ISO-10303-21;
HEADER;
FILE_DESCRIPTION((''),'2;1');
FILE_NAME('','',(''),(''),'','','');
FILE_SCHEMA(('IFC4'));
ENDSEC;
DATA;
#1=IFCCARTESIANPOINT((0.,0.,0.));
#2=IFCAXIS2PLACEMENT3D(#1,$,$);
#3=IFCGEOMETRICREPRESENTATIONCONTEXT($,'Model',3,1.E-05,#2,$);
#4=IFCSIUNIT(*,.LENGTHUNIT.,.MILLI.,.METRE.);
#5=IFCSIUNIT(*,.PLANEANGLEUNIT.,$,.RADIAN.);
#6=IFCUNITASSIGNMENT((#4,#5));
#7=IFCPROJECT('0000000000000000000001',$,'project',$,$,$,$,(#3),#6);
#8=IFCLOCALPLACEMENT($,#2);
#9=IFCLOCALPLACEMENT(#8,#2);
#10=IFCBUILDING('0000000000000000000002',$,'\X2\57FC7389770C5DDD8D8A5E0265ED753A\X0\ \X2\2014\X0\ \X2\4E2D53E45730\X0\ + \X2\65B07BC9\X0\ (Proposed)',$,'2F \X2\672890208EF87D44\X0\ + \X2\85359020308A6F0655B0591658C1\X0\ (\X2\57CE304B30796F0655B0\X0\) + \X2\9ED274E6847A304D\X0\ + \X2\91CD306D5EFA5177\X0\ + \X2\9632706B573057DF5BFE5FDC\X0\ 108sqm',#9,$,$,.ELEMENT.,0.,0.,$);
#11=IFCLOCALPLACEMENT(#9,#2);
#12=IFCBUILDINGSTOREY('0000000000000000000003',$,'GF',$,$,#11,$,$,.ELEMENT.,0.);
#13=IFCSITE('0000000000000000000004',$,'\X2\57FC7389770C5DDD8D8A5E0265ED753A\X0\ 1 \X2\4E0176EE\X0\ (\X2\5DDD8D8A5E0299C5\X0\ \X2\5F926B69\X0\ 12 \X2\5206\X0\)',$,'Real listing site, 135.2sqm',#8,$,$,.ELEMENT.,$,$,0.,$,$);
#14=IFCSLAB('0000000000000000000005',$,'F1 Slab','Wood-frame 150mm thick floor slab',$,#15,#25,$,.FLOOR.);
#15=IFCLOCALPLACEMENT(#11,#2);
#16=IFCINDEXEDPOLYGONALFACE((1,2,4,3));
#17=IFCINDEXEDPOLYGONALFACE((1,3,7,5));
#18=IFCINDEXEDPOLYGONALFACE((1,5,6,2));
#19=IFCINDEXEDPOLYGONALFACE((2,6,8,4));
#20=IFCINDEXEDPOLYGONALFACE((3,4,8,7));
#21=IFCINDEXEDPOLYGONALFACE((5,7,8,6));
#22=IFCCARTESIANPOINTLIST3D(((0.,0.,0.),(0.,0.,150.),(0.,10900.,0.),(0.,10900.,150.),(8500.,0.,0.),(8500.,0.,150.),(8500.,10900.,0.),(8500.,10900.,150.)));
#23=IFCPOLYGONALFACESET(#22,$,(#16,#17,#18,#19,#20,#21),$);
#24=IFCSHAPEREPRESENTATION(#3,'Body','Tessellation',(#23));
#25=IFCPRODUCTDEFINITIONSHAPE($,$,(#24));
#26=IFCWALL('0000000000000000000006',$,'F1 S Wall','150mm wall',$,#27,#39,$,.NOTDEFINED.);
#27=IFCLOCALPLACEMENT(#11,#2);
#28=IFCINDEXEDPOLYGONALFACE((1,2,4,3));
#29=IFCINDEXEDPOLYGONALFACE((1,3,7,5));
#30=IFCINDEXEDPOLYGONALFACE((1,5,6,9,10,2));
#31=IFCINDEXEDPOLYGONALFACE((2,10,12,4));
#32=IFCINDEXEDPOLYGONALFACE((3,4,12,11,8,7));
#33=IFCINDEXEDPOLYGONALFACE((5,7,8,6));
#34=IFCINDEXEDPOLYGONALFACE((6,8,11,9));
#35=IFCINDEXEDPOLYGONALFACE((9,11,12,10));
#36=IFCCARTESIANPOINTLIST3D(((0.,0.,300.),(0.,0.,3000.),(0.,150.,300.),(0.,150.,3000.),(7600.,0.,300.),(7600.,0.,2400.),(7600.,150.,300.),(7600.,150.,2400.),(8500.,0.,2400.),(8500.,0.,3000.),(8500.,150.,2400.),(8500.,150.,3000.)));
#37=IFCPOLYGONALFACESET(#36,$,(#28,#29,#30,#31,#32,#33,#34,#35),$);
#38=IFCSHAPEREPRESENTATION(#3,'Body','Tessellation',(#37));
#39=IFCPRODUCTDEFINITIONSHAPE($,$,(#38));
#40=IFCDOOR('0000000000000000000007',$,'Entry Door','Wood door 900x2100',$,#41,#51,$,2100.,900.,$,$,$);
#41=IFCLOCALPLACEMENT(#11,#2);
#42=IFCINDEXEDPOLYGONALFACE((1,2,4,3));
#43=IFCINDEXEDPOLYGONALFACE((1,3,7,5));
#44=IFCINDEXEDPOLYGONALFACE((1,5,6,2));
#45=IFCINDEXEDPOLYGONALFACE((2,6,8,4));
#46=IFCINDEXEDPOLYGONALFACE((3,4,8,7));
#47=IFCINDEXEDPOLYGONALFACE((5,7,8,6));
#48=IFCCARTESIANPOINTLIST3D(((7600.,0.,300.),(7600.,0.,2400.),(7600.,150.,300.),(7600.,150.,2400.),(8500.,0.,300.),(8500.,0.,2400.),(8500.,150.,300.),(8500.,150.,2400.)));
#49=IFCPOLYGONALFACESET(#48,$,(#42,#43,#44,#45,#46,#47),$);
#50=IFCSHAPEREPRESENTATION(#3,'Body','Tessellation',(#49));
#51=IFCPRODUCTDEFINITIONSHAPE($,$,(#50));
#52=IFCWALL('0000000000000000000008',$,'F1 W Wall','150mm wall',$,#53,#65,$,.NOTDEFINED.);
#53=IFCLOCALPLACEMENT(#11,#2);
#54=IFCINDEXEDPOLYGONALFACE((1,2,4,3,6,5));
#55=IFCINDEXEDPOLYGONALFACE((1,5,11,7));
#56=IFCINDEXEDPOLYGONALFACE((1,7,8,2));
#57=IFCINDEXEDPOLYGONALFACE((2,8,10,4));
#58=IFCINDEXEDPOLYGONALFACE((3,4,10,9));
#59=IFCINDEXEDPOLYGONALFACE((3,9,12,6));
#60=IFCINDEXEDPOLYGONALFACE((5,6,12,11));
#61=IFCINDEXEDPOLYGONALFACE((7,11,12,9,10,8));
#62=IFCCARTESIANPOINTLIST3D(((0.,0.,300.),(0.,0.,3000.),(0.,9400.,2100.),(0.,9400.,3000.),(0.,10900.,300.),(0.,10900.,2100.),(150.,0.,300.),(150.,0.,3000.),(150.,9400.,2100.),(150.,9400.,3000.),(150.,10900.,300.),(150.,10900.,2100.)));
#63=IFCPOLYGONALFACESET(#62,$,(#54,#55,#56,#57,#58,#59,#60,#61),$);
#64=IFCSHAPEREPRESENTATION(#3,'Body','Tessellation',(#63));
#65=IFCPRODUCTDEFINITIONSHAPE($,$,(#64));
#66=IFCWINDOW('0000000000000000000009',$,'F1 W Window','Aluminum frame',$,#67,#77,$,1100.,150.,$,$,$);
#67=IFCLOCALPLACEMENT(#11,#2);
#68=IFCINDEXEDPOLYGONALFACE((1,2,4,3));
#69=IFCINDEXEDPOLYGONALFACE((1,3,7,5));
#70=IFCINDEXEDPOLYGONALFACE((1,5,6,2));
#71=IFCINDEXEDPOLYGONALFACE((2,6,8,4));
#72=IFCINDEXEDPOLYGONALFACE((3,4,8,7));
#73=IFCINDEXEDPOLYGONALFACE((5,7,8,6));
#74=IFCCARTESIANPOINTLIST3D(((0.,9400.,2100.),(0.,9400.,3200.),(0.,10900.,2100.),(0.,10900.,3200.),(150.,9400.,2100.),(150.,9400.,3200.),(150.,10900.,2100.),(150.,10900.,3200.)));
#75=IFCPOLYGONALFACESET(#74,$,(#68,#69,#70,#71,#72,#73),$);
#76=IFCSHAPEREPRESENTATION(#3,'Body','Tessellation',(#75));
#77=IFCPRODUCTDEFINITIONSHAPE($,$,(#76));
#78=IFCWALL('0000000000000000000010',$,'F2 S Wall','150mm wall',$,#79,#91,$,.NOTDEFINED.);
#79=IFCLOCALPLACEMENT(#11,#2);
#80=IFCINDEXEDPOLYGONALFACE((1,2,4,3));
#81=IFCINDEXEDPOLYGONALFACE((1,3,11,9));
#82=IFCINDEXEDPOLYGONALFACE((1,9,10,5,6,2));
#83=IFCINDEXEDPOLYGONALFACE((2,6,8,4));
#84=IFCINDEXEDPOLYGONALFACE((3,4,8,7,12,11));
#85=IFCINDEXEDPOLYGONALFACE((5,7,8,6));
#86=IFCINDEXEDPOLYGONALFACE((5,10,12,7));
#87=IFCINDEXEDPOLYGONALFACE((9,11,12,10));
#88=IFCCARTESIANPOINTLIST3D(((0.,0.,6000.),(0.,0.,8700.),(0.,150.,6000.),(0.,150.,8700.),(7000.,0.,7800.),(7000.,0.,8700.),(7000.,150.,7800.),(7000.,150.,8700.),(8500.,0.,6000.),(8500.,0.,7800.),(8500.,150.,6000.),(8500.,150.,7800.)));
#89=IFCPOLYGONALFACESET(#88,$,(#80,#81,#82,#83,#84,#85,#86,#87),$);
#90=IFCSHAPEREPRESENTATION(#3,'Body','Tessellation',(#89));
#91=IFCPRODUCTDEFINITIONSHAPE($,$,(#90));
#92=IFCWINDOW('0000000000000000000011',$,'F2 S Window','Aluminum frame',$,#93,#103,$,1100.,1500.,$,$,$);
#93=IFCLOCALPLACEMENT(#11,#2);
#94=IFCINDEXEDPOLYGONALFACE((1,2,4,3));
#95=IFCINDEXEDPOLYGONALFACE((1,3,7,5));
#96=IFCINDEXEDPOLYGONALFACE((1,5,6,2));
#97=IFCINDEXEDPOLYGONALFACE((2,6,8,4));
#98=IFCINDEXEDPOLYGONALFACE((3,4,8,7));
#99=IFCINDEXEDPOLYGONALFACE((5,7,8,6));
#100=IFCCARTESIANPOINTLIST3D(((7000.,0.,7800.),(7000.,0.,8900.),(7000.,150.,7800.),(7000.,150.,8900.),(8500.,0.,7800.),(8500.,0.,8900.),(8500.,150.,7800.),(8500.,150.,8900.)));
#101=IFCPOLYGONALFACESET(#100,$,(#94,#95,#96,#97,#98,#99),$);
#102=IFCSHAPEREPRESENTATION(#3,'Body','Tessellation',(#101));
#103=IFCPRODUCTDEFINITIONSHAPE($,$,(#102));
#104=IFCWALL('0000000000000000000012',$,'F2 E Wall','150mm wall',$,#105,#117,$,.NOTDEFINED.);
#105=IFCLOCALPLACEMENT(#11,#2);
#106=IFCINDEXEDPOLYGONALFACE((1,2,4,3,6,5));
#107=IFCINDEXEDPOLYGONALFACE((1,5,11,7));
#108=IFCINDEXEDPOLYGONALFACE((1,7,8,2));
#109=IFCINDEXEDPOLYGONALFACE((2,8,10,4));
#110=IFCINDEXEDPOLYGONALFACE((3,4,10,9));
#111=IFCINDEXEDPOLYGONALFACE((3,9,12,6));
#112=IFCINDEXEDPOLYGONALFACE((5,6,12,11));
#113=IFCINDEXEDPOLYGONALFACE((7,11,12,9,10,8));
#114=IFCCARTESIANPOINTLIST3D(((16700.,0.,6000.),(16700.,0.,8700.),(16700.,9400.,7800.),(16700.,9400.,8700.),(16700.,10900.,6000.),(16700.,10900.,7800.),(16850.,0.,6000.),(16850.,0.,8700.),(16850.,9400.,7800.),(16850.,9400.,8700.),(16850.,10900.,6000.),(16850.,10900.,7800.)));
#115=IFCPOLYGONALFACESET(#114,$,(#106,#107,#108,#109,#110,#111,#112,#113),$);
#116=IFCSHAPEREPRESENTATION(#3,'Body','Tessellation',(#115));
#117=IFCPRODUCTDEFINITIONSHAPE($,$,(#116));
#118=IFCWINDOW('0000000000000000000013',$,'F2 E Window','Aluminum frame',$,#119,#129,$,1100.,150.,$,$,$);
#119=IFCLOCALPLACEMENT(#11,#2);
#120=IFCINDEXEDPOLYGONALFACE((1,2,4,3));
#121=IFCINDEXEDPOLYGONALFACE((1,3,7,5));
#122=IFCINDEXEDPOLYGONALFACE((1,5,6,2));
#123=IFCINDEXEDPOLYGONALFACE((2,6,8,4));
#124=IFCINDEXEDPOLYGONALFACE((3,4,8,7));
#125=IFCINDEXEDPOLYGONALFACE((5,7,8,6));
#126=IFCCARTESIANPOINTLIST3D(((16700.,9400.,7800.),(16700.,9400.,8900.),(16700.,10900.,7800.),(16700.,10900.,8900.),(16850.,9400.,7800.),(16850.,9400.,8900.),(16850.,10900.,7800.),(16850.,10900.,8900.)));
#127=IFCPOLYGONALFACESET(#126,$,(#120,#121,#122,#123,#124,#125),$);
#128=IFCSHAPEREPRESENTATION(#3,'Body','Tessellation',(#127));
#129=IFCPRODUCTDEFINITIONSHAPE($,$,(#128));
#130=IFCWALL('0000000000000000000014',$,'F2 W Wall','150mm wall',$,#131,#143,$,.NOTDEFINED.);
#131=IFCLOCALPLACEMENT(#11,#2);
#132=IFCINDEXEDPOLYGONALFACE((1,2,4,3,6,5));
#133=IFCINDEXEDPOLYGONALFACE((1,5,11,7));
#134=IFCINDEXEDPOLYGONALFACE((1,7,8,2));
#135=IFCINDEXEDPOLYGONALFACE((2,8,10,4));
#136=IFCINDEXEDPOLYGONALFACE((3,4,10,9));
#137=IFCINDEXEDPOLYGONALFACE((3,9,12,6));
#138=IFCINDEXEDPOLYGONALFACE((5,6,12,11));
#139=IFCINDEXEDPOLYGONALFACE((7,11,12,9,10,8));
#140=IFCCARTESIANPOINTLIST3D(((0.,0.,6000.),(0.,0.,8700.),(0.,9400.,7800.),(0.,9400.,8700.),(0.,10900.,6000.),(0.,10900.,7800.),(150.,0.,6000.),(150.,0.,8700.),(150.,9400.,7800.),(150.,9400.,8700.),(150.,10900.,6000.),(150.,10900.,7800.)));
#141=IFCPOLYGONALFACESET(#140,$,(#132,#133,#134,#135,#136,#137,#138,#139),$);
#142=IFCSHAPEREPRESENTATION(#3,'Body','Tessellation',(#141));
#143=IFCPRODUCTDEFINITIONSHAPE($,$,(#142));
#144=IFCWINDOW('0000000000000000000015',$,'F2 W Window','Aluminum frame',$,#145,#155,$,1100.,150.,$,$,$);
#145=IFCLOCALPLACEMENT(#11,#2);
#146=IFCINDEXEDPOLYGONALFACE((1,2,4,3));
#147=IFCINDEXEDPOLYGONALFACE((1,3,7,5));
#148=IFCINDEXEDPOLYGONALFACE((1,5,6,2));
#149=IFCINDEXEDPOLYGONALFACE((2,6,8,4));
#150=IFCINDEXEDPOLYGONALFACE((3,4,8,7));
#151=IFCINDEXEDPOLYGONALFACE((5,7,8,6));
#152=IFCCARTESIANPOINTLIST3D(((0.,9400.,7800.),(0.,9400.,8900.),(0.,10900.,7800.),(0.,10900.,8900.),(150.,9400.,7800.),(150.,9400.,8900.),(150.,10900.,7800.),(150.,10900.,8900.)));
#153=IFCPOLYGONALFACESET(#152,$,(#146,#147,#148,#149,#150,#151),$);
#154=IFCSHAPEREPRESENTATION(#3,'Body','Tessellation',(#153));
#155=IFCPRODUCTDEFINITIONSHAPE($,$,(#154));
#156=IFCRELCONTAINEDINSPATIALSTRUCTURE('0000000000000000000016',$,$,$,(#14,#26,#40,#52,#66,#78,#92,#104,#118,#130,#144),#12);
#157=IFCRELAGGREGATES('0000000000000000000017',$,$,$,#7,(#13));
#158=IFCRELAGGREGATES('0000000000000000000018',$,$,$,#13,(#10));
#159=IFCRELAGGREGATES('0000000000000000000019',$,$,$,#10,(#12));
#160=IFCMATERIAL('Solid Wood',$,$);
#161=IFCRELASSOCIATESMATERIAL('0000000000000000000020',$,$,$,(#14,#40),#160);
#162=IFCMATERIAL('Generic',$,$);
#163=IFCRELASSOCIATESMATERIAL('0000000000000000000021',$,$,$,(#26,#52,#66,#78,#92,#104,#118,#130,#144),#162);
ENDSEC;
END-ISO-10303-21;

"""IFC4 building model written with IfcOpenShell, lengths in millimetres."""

from ifc_helpers import new_model, si_unit, frame, frame_2d, origin, place, context, project, spatial, rectangle, extrude, material, element, fill, save


model = new_model("IFC4")

# Units and contexts
model_context = context("Model", 3, precision=1e-05, world=origin())
ifc_project = project(units=[si_unit("LENGTHUNIT", "METRE", prefix="MILLI"), si_unit("PLANEANGLEUNIT", "RADIAN")], contexts=[model_context])

# Site, building, storey
site_placement = place(None, origin())
site = spatial("IfcSite", under=ifc_project, at=site_placement, Name="埼玉県川越市旭町 1 丁目 (川越市駅 徒歩 12 分)", ObjectType="Real listing site, 135.2sqm", CompositionType="ELEMENT", RefElevation=0.0)
building_placement = place(site_placement, origin())
building = spatial("IfcBuilding", under=site, at=building_placement, Name="埼玉県川越市旭町 — 中古地 + 新築 (Proposed)", ObjectType="2F 木造軸組 + 蔵造り漆喰外壁 (城かべ漆喰) + 黒瓦葺き + 重ね建具 + 防火地域対応 108sqm", CompositionType="ELEMENT", ElevationOfRefHeight=0.0, ElevationOfTerrain=0.0)
storey_placement = place(building_placement, origin())
storey = spatial("IfcBuildingStorey", under=building, at=storey_placement, Name="GF", CompositionType="ELEMENT", Elevation=0.0)

# Slab
ifc_material_1 = material(Name="Solid Wood")
slab_1_placement = place(storey_placement, origin())
element("IfcSlab", 1, at=slab_1_placement, inside=storey, material=ifc_material_1, Name="F1 Slab", Description="Wood-frame 150mm thick floor slab", PredefinedType="FLOOR", context=model_context, shape_type="SweptSolid", body=[
    extrude(rectangle(XDim=8500.0, YDim=10900.0, at=frame_2d((4250.0, 5450.0))), origin(), (0.0, 0.0, 1.0), 150.0),
])

# Shared definitions
ifc_material_2 = material(Name="Generic")

# Wall, opening, door
wall_1_placement = place(storey_placement, frame((0.0, 0.0, 150.0)))
wall_1 = element("IfcWall", 2, at=wall_1_placement, inside=storey, material=ifc_material_2, Name="F1 S Wall", Description="150mm wall", PredefinedType="NOTDEFINED", context=model_context, shape_type="SweptSolid", body=[
    extrude(rectangle(XDim=8500.0, YDim=150.0, at=frame_2d((4250.0, 75.0))), frame((0.0, 0.0, 150.0)), (0.0, 0.0, 1.0), 2700.0),
])
opening_1_placement = place(storey_placement, frame((3800.0, 0.0, 150.0)))
opening_1 = element("IfcOpeningElement", 3, at=opening_1_placement, cuts=wall_1, PredefinedType="NOTDEFINED", context=model_context, shape_type="SweptSolid", body=[
    extrude(rectangle(XDim=900.0, YDim=150.0, at=frame_2d((450.0, 75.0))), frame((3800.0, 0.0, 150.0)), (0.0, 0.0, 1.0), 2100.0),
])
door_placement = place(storey_placement, frame((3800.0, 0.0, 150.0)))
door = element("IfcDoor", 4, at=door_placement, inside=storey, material=ifc_material_1, Name="Entry Door", Description="Wood door 900x2100", OverallHeight=2100.0, OverallWidth=900.0, context=model_context, shape_type="SweptSolid", body=[
    extrude(rectangle(XDim=900.0, YDim=150.0, at=frame_2d((450.0, 75.0))), frame((3800.0, 0.0, 150.0)), (0.0, 0.0, 1.0), 2100.0),
])
fill(opening_1, door)

# Walls, openings, windows
wall_2_placement = place(storey_placement, frame((0.0, 0.0, 150.0)))
wall_2 = element("IfcWall", 5, at=wall_2_placement, inside=storey, material=ifc_material_2, Name="F1 W Wall", Description="150mm wall", PredefinedType="NOTDEFINED", context=model_context, shape_type="SweptSolid", body=[
    extrude(rectangle(XDim=150.0, YDim=10900.0, at=frame_2d((75.0, 5450.0))), frame((0.0, 0.0, 150.0)), (0.0, 0.0, 1.0), 2700.0),
])
opening_2_placement = place(storey_placement, frame((0.0, 4700.0, 1050.0)))
opening_2 = element("IfcOpeningElement", 6, at=opening_2_placement, cuts=wall_2, PredefinedType="NOTDEFINED", context=model_context, shape_type="SweptSolid", body=[
    extrude(rectangle(XDim=150.0, YDim=1500.0, at=frame_2d((75.0, 750.0))), frame((0.0, 4700.0, 1050.0)), (0.0, 0.0, 1.0), 1100.0),
])
window_1_placement = place(storey_placement, frame((0.0, 4700.0, 1050.0)))
window_1 = element("IfcWindow", 7, at=window_1_placement, inside=storey, material=ifc_material_2, Name="F1 W Window", Description="Aluminum frame", OverallHeight=1100.0, OverallWidth=150.0, context=model_context, shape_type="SweptSolid", body=[
    extrude(rectangle(XDim=150.0, YDim=1500.0, at=frame_2d((75.0, 750.0))), frame((0.0, 4700.0, 1050.0)), (0.0, 0.0, 1.0), 1100.0),
])
fill(opening_2, window_1)
wall_3_placement = place(storey_placement, frame((0.0, 0.0, 3000.0)))
wall_3 = element("IfcWall", 8, at=wall_3_placement, inside=storey, material=ifc_material_2, Name="F2 S Wall", Description="150mm wall", PredefinedType="NOTDEFINED", context=model_context, shape_type="SweptSolid", body=[
    extrude(rectangle(XDim=8500.0, YDim=150.0, at=frame_2d((4250.0, 75.0))), frame((0.0, 0.0, 3000.0)), (0.0, 0.0, 1.0), 2700.0),
])
opening_3_placement = place(storey_placement, frame((3500.0, 0.0, 3900.0)))
opening_3 = element("IfcOpeningElement", 9, at=opening_3_placement, cuts=wall_3, PredefinedType="NOTDEFINED", context=model_context, shape_type="SweptSolid", body=[
    extrude(rectangle(XDim=1500.0, YDim=150.0, at=frame_2d((750.0, 75.0))), frame((3500.0, 0.0, 3900.0)), (0.0, 0.0, 1.0), 1100.0),
])
window_2_placement = place(storey_placement, frame((3500.0, 0.0, 3900.0)))
window_2 = element("IfcWindow", 10, at=window_2_placement, inside=storey, material=ifc_material_2, Name="F2 S Window", Description="Aluminum frame", OverallHeight=1100.0, OverallWidth=1500.0, context=model_context, shape_type="SweptSolid", body=[
    extrude(rectangle(XDim=1500.0, YDim=150.0, at=frame_2d((750.0, 75.0))), frame((3500.0, 0.0, 3900.0)), (0.0, 0.0, 1.0), 1100.0),
])
fill(opening_3, window_2)
wall_4_placement = place(storey_placement, frame((8350.0, 0.0, 3000.0)))
wall_4 = element("IfcWall", 11, at=wall_4_placement, inside=storey, material=ifc_material_2, Name="F2 E Wall", Description="150mm wall", PredefinedType="NOTDEFINED", context=model_context, shape_type="SweptSolid", body=[
    extrude(rectangle(XDim=150.0, YDim=10900.0, at=frame_2d((75.0, 5450.0))), frame((8350.0, 0.0, 3000.0)), (0.0, 0.0, 1.0), 2700.0),
])
opening_4_placement = place(storey_placement, frame((8350.0, 4700.0, 3900.0)))
opening_4 = element("IfcOpeningElement", 12, at=opening_4_placement, cuts=wall_4, PredefinedType="NOTDEFINED", context=model_context, shape_type="SweptSolid", body=[
    extrude(rectangle(XDim=150.0, YDim=1500.0, at=frame_2d((75.0, 750.0))), frame((8350.0, 4700.0, 3900.0)), (0.0, 0.0, 1.0), 1100.0),
])
window_3_placement = place(storey_placement, frame((8350.0, 4700.0, 3900.0)))
window_3 = element("IfcWindow", 13, at=window_3_placement, inside=storey, material=ifc_material_2, Name="F2 E Window", Description="Aluminum frame", OverallHeight=1100.0, OverallWidth=150.0, context=model_context, shape_type="SweptSolid", body=[
    extrude(rectangle(XDim=150.0, YDim=1500.0, at=frame_2d((75.0, 750.0))), frame((8350.0, 4700.0, 3900.0)), (0.0, 0.0, 1.0), 1100.0),
])
fill(opening_4, window_3)
wall_5_placement = place(storey_placement, frame((0.0, 0.0, 3000.0)))
wall_5 = element("IfcWall", 14, at=wall_5_placement, inside=storey, material=ifc_material_2, Name="F2 W Wall", Description="150mm wall", PredefinedType="NOTDEFINED", context=model_context, shape_type="SweptSolid", body=[
    extrude(rectangle(XDim=150.0, YDim=10900.0, at=frame_2d((75.0, 5450.0))), frame((0.0, 0.0, 3000.0)), (0.0, 0.0, 1.0), 2700.0),
])
opening_5_placement = place(storey_placement, frame((0.0, 4700.0, 3900.0)))
opening_5 = element("IfcOpeningElement", 15, at=opening_5_placement, cuts=wall_5, PredefinedType="NOTDEFINED", context=model_context, shape_type="SweptSolid", body=[
    extrude(rectangle(XDim=150.0, YDim=1500.0, at=frame_2d((75.0, 750.0))), frame((0.0, 4700.0, 3900.0)), (0.0, 0.0, 1.0), 1100.0),
])
window_4_placement = place(storey_placement, frame((0.0, 4700.0, 3900.0)))
window_4 = element("IfcWindow", 16, at=window_4_placement, inside=storey, material=ifc_material_2, Name="F2 W Window", Description="Aluminum frame", OverallHeight=1100.0, OverallWidth=150.0, context=model_context, shape_type="SweptSolid", body=[
    extrude(rectangle(XDim=150.0, YDim=1500.0, at=frame_2d((75.0, 750.0))), frame((0.0, 4700.0, 3900.0)), (0.0, 0.0, 1.0), 1100.0),
])
fill(opening_5, window_4)

save(model, "model.ifc")
